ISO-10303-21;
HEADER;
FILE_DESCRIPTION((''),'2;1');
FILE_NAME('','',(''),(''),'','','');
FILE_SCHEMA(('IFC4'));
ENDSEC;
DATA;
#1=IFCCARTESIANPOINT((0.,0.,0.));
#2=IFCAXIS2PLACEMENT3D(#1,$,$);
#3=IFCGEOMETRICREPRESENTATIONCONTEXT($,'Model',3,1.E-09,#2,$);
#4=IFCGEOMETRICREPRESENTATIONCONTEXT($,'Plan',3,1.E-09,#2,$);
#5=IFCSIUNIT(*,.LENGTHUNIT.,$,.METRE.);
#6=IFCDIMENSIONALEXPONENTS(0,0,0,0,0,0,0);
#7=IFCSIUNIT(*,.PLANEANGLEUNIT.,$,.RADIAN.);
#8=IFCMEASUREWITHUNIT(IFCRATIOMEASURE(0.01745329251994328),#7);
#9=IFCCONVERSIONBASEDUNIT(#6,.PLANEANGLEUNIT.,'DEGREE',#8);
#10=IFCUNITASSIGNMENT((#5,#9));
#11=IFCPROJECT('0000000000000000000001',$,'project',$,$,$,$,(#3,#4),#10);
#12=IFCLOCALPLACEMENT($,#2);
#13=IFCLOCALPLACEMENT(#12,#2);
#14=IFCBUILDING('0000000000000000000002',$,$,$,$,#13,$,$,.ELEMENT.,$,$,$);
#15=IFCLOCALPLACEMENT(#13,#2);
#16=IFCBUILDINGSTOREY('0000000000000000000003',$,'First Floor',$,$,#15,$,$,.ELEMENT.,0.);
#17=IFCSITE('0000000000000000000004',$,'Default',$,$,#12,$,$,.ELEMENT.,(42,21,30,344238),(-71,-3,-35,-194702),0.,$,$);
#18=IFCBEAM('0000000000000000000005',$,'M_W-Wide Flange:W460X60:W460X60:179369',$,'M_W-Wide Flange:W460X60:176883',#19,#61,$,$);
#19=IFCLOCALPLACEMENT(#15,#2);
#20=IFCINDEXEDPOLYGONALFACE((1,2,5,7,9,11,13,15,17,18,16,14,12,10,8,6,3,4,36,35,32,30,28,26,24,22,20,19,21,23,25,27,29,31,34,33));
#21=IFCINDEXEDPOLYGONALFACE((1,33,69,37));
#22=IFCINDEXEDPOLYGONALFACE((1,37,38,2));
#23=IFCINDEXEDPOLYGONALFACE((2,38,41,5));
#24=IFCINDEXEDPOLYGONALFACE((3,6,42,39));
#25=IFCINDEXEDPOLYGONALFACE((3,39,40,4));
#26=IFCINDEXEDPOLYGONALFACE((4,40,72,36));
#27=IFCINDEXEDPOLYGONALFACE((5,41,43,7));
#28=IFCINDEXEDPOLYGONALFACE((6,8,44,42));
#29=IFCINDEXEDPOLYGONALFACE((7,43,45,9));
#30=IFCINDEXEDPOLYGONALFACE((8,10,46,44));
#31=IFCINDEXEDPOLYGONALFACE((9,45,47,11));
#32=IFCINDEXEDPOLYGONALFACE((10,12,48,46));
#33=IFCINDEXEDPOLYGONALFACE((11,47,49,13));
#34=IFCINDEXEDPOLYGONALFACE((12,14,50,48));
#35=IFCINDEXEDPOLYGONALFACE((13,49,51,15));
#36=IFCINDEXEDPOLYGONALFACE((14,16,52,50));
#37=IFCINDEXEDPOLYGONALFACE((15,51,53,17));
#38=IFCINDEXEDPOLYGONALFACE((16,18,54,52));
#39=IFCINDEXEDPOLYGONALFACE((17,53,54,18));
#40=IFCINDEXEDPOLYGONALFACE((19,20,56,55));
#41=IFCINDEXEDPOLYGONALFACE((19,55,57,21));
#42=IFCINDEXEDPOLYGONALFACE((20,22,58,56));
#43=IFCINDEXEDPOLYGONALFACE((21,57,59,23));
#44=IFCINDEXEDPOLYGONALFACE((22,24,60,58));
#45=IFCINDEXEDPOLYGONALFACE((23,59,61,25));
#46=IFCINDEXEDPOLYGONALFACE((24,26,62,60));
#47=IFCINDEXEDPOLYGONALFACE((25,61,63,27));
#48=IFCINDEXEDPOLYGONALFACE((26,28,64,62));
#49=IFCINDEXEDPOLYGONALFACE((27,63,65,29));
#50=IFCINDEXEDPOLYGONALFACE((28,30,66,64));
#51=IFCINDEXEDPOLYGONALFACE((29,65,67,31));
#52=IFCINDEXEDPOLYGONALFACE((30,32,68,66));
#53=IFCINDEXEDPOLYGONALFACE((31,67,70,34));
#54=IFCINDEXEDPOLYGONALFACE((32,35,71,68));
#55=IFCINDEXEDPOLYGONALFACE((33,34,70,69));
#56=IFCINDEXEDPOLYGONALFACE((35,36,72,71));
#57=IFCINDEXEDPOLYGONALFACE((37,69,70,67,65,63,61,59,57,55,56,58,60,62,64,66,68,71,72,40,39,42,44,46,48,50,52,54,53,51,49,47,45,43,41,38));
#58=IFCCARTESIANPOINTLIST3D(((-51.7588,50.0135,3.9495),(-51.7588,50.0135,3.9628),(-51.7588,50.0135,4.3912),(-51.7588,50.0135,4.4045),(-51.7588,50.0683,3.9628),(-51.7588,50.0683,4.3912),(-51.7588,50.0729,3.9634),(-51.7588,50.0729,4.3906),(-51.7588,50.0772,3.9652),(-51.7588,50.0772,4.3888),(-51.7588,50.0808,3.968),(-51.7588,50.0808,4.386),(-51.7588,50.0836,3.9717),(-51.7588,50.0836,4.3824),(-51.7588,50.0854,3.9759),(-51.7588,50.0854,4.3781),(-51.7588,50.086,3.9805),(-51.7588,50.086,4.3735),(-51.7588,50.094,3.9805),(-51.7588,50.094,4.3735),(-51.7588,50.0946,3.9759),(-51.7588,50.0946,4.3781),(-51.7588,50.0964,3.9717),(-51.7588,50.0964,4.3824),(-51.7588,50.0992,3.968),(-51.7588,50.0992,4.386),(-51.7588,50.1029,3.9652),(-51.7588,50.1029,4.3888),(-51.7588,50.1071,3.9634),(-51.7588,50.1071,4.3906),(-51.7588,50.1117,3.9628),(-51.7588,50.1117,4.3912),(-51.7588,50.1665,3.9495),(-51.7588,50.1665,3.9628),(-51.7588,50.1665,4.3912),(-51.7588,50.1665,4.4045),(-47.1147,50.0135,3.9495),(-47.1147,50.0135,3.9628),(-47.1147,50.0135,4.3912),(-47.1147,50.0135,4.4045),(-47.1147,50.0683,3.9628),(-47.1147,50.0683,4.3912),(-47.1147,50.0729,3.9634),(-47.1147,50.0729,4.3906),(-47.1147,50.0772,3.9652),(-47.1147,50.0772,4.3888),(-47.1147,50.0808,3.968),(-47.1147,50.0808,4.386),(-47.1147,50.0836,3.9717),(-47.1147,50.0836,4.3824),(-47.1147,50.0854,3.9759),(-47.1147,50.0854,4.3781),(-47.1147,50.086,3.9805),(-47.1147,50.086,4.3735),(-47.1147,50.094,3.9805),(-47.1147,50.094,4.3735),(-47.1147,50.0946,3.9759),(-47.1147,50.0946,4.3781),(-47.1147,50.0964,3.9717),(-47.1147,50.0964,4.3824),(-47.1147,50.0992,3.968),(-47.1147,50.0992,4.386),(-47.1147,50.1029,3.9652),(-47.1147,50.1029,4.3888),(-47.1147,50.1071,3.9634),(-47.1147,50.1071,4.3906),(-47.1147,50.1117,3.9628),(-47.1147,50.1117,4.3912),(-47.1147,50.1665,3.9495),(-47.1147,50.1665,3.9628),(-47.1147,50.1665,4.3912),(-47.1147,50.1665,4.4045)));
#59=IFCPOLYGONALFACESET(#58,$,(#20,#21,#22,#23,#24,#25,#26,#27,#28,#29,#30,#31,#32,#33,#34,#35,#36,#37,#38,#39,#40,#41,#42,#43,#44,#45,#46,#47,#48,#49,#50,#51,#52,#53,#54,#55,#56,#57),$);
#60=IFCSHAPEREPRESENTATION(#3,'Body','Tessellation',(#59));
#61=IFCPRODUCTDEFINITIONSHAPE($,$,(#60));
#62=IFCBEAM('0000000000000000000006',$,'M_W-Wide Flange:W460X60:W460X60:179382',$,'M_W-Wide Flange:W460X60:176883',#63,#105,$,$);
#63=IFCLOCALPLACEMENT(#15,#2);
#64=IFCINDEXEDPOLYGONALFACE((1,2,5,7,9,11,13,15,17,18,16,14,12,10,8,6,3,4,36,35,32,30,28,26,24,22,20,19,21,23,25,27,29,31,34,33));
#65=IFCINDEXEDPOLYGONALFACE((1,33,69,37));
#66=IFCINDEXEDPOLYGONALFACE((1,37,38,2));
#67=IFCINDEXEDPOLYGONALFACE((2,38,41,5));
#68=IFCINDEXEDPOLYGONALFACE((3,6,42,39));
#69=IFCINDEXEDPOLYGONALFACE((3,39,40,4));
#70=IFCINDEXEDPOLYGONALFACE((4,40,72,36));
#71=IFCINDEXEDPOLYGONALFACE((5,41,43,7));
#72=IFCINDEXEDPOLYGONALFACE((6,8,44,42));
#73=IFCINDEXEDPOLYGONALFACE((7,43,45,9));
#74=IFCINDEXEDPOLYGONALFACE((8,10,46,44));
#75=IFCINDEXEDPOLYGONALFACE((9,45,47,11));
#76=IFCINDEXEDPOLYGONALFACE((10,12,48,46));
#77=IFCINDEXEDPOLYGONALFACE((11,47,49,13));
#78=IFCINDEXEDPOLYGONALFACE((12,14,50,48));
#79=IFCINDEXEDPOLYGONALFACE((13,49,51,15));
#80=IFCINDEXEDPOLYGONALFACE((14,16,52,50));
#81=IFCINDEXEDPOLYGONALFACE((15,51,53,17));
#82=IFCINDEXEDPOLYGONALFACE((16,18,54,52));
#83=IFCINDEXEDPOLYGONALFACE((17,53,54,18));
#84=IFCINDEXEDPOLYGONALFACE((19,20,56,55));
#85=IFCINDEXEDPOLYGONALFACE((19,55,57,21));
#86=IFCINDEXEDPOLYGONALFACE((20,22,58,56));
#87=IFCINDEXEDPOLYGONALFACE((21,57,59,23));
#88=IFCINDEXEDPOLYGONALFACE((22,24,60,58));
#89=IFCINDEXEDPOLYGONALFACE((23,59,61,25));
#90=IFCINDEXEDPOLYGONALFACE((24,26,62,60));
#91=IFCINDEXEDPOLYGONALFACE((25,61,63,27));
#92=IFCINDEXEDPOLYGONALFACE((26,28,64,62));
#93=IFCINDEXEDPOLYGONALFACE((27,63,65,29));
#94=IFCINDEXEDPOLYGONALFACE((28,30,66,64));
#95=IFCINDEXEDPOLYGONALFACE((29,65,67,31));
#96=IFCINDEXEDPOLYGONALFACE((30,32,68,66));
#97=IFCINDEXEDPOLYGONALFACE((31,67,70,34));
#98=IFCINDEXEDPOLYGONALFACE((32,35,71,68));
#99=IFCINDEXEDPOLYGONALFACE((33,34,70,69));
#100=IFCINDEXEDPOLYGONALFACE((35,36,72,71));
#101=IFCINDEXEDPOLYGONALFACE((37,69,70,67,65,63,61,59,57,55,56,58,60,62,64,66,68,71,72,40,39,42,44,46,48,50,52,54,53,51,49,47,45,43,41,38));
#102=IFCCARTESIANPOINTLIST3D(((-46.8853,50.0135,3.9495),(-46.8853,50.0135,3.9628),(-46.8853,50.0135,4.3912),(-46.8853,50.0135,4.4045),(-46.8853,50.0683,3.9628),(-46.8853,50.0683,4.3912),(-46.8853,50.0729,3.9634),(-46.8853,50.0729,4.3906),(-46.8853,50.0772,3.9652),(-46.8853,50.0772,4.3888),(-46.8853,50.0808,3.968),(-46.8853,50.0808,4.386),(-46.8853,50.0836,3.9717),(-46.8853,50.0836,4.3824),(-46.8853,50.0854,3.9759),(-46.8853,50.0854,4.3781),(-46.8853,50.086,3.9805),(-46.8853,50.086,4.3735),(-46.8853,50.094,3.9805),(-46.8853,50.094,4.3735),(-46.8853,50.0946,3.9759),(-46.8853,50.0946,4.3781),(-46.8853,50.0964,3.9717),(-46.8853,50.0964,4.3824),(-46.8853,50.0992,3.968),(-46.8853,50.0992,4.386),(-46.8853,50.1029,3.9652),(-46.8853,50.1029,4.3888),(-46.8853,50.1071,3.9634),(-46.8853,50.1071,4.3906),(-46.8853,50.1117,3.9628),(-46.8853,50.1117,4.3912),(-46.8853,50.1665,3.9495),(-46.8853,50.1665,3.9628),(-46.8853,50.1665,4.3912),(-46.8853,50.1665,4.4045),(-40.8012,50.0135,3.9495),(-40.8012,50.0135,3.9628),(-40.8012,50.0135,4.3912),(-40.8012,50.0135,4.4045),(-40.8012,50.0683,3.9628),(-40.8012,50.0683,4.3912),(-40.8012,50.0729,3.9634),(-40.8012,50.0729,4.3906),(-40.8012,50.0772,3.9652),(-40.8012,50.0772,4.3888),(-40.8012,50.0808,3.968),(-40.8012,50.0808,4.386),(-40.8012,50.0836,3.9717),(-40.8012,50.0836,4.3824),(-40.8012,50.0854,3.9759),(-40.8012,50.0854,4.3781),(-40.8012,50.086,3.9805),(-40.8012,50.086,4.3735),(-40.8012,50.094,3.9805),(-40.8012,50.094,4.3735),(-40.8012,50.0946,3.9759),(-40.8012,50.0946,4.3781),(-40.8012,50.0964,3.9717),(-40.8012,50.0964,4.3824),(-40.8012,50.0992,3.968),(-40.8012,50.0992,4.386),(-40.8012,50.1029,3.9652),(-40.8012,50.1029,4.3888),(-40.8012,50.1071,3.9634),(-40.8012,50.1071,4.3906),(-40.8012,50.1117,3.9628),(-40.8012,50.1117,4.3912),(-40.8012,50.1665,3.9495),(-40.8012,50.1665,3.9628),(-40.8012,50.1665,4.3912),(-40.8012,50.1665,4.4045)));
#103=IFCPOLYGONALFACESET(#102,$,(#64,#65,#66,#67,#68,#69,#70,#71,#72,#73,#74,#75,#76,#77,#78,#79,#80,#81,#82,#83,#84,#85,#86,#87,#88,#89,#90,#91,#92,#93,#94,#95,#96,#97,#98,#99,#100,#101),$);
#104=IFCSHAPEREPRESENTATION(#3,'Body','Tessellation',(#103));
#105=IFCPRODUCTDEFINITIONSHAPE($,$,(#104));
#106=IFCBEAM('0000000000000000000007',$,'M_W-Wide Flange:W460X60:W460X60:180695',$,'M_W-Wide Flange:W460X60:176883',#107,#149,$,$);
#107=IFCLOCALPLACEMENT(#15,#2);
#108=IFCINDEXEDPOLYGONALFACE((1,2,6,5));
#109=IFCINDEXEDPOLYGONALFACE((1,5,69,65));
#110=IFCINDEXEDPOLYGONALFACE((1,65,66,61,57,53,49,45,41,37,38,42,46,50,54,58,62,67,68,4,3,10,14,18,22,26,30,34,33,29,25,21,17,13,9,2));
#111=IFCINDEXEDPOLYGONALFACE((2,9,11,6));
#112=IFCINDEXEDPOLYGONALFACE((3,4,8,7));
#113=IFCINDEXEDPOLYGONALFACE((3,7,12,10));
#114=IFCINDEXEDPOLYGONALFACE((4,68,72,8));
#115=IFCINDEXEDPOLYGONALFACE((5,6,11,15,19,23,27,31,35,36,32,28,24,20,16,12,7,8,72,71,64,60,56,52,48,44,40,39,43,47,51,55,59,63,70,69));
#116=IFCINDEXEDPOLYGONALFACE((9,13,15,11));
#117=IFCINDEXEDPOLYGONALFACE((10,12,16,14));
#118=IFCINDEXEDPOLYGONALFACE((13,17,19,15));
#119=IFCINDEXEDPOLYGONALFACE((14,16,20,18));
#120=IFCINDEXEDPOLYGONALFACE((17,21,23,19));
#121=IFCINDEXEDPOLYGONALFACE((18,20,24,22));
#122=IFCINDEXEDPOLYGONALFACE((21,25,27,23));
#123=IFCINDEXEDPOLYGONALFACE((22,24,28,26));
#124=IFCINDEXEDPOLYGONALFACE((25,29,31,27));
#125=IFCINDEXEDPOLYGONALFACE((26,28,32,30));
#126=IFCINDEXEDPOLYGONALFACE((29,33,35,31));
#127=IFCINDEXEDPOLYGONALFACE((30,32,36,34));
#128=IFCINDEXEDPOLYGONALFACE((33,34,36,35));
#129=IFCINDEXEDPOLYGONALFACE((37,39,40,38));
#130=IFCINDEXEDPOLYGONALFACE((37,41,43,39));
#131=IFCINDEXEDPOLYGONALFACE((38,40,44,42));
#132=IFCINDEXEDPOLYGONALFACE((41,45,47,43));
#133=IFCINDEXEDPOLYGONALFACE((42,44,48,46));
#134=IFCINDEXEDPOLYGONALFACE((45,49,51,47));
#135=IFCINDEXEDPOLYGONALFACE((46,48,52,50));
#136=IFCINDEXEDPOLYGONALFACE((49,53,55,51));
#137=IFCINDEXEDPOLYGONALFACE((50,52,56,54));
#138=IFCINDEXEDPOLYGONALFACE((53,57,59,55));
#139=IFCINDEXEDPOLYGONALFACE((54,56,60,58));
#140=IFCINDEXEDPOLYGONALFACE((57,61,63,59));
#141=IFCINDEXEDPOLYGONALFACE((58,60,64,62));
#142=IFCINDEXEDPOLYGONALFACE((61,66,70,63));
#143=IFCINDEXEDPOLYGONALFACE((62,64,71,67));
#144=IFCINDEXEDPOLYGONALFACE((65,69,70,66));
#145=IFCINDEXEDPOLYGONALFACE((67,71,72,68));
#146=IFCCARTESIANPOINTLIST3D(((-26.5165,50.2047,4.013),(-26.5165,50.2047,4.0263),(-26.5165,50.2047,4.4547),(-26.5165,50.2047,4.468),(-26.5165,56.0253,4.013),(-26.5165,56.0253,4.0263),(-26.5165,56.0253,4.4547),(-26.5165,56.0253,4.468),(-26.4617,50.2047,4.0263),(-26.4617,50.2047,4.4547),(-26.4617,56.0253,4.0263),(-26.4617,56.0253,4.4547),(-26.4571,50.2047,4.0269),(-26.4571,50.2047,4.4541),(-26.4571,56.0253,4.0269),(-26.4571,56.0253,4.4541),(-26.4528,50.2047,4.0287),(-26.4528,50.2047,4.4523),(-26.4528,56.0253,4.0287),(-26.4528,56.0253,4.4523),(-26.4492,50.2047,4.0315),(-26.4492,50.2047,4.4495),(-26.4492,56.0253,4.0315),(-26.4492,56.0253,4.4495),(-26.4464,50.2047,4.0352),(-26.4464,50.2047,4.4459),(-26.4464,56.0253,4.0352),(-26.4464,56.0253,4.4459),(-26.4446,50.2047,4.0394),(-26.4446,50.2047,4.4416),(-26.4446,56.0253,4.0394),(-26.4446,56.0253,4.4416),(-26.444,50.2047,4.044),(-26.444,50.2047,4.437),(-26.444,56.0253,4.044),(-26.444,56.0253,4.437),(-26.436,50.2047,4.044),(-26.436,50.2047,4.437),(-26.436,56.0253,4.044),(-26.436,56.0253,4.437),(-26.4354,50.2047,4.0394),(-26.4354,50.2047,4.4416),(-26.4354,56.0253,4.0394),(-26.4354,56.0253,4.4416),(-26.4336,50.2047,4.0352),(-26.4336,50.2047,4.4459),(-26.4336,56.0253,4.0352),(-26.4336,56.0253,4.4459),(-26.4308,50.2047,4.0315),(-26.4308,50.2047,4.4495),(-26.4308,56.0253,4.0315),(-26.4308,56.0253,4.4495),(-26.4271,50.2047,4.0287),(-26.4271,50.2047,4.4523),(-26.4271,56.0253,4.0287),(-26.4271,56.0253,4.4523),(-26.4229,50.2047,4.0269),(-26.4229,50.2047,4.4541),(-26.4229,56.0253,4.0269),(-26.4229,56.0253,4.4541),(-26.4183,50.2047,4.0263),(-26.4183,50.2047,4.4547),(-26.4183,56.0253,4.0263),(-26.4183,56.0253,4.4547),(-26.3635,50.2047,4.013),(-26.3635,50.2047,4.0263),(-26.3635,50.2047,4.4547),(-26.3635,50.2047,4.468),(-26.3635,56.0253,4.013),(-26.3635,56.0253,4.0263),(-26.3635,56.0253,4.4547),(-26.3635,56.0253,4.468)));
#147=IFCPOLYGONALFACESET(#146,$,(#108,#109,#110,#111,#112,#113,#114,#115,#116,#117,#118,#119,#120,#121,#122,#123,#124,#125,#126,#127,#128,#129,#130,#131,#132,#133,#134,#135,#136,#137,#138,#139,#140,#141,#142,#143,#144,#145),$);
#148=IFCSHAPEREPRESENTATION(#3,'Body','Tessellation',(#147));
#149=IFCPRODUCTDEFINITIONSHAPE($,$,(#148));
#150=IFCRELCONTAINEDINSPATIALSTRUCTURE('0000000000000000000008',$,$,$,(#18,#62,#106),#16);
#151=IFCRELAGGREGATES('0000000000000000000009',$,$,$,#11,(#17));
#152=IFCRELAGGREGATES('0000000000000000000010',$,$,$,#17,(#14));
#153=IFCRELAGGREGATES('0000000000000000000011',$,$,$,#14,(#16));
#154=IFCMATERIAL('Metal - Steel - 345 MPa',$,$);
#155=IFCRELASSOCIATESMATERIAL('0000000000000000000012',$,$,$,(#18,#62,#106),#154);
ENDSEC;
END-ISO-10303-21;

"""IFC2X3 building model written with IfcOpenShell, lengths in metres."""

from ifc_helpers import new_model, entity, si_unit, converted_unit, frame, frame_2d, origin, place, context, project, spatial, polyline, circle_curve, parameter, trimmed, segment, composite_curve, outline, extrude, material, element, save


model = new_model("IFC2X3")

# Units and contexts
model_context = context("Model", 3, precision=1e-09, world=origin())
plan_context = context("Plan", 3, precision=1e-09, world=origin())
ifc_project = project(units=[si_unit("LENGTHUNIT", "METRE"), converted_unit("PLANEANGLEUNIT", "DEGREE", entity("IfcRatioMeasure", 0.01745329251994328), si_unit("PLANEANGLEUNIT", "RADIAN"), dimensions=[0, 0, 0, 0, 0, 0, 0])], contexts=[model_context, plan_context])

# Site, building, storey
site_placement = place(None, origin())
site = spatial("IfcSite", under=ifc_project, at=site_placement, Name="Default", CompositionType="ELEMENT", RefLatitude=(42, 21, 30, 344238), RefLongitude=(-71, -3, -35, -194702), RefElevation=0.0)
building_placement = place(site_placement, origin())
building = spatial("IfcBuilding", under=site, at=building_placement, CompositionType="ELEMENT")
storey_placement = place(building_placement, origin())
storey = spatial("IfcBuildingStorey", under=building, at=storey_placement, Name="First Floor", CompositionType="ELEMENT", Elevation=0.0)

# Beams
ifc_material = material(Name="Metal - Steel - 345 MPa")
beam_1_placement = place(storey_placement, frame((-51.9028, 50.09, 4.4045), z_axis=(0.0, 0.0, 1.0), x_axis=(0.0, -1.0, 0.0)))
element("IfcBeam", 1, at=beam_1_placement, inside=storey, material=ifc_material, Name="M_W-Wide Flange:W460X60:W460X60:179369", ObjectType="M_W-Wide Flange:W460X60:176883", context=model_context, shape_type="SweptSolid", body=[
    extrude(outline(composite_curve([segment(polyline([(-0.0765, -0.2142), (-0.0765, -0.2275)]), True, "CONTINUOUS"), segment(polyline([(-0.0765, -0.2275), (0.0765, -0.2275)]), True, "CONTINUOUS"), segment(polyline([(0.0765, -0.2275), (0.0765, -0.2142)]), True, "CONTINUOUS"), segment(polyline([(0.0765, -0.2142), (0.0217, -0.2142)]), True, "CONTINUOUS"), segment(trimmed(circle_curve(frame_2d((0.0217, -0.1965), x_axis=(1.0, 0.0)), 0.0177), [parameter(180.0)], [parameter(270.0)], True, "PARAMETER"), False, "CONTINUOUS"), segment(polyline([(0.004, -0.1965), (0.004, 0.1965)]), True, "CONTINUOUS"), segment(trimmed(circle_curve(frame_2d((0.0217, 0.1965), x_axis=(1.0, 0.0)), 0.0177), [parameter(90.0)], [parameter(180.0)], True, "PARAMETER"), False, "CONTINUOUS"), segment(polyline([(0.0217, 0.2142), (0.0765, 0.2142)]), True, "CONTINUOUS"), segment(polyline([(0.0765, 0.2142), (0.0765, 0.2275)]), True, "CONTINUOUS"), segment(polyline([(0.0765, 0.2275), (-0.0765, 0.2275)]), True, "CONTINUOUS"), segment(polyline([(-0.0765, 0.2275), (-0.0765, 0.2142)]), True, "CONTINUOUS"), segment(polyline([(-0.0765, 0.2142), (-0.0217, 0.2142)]), True, "CONTINUOUS"), segment(trimmed(circle_curve(frame_2d((-0.0217, 0.1965), x_axis=(1.0, 0.0)), 0.0177), [parameter(360.0)], [parameter(90.0)], True, "PARAMETER"), False, "CONTINUOUS"), segment(polyline([(-0.004, 0.1965), (-0.004, -0.1965)]), True, "CONTINUOUS"), segment(trimmed(circle_curve(frame_2d((-0.0217, -0.1965), x_axis=(1.0, 0.0)), 0.0177), [parameter(270.0)], [parameter(0.0)], True, "PARAMETER"), False, "CONTINUOUS"), segment(polyline([(-0.0217, -0.2142), (-0.0765, -0.2142)]), True, "CONTINUOUS")], self_intersect=False)), frame((0.0, 0.144, -0.2275), z_axis=(0.0, -1.0, 0.0), x_axis=(1.0, 0.0, 0.0)), (0.0, 0.0, -1.0), 4.6441),
])
beam_2_placement = place(storey_placement, frame((-47.0022, 50.09, 4.4045), z_axis=(0.0, 0.0, 1.0), x_axis=(0.0, -1.0, 0.0)))
element("IfcBeam", 2, at=beam_2_placement, inside=storey, material=ifc_material, Name="M_W-Wide Flange:W460X60:W460X60:179382", ObjectType="M_W-Wide Flange:W460X60:176883", context=model_context, shape_type="SweptSolid", body=[
    extrude(outline(composite_curve([segment(polyline([(-0.0765, -0.2142), (-0.0765, -0.2275)]), True, "CONTINUOUS"), segment(polyline([(-0.0765, -0.2275), (0.0765, -0.2275)]), True, "CONTINUOUS"), segment(polyline([(0.0765, -0.2275), (0.0765, -0.2142)]), True, "CONTINUOUS"), segment(polyline([(0.0765, -0.2142), (0.0217, -0.2142)]), True, "CONTINUOUS"), segment(trimmed(circle_curve(frame_2d((0.0217, -0.1965), x_axis=(0.0, -1.0)), 0.0177), [parameter(270.0)], [parameter(360.0)], True, "PARAMETER"), False, "CONTINUOUS"), segment(polyline([(0.004, -0.1965), (0.004, 0.1965)]), True, "CONTINUOUS"), segment(trimmed(circle_curve(frame_2d((0.0217, 0.1965), x_axis=(-1.0, 0.0)), 0.0177), [parameter(270.0)], [parameter(360.0)], True, "PARAMETER"), False, "CONTINUOUS"), segment(polyline([(0.0217, 0.2142), (0.0765, 0.2142)]), True, "CONTINUOUS"), segment(polyline([(0.0765, 0.2142), (0.0765, 0.2275)]), True, "CONTINUOUS"), segment(polyline([(0.0765, 0.2275), (-0.0765, 0.2275)]), True, "CONTINUOUS"), segment(polyline([(-0.0765, 0.2275), (-0.0765, 0.2142)]), True, "CONTINUOUS"), segment(polyline([(-0.0765, 0.2142), (-0.0217, 0.2142)]), True, "CONTINUOUS"), segment(trimmed(circle_curve(frame_2d((-0.0217, 0.1965), x_axis=(0.0, 1.0)), 0.0177), [parameter(270.0)], [parameter(360.0)], True, "PARAMETER"), False, "CONTINUOUS"), segment(polyline([(-0.004, 0.1965), (-0.004, -0.1965)]), True, "CONTINUOUS"), segment(trimmed(circle_curve(frame_2d((-0.0217, -0.1965), x_axis=(1.0, 0.0)), 0.0177), [parameter(270.0)], [parameter(0.0)], True, "PARAMETER"), False, "CONTINUOUS"), segment(polyline([(-0.0217, -0.2142), (-0.0765, -0.2142)]), True, "CONTINUOUS")], self_intersect=False)), frame((0.0, 0.1169, -0.2275), z_axis=(0.0, -1.0, 0.0), x_axis=(1.0, 0.0, 0.0)), (0.0, 0.0, -1.0), 6.0841),
])
beam_3_placement = place(storey_placement, frame((-26.44, 56.1423, 4.468), z_axis=(0.0, 0.0, 1.0), x_axis=(-1.0, 0.0, 0.0)))
element("IfcBeam", 3, at=beam_3_placement, inside=storey, material=ifc_material, Name="M_W-Wide Flange:W460X60:W460X60:180695", ObjectType="M_W-Wide Flange:W460X60:176883", context=model_context, shape_type="SweptSolid", body=[
    extrude(outline(composite_curve([segment(polyline([(0.2142, -0.0765), (0.2275, -0.0765)]), True, "CONTINUOUS"), segment(polyline([(0.2275, -0.0765), (0.2275, 0.0765)]), True, "CONTINUOUS"), segment(polyline([(0.2275, 0.0765), (0.2142, 0.0765)]), True, "CONTINUOUS"), segment(polyline([(0.2142, 0.0765), (0.2142, 0.0217)]), True, "CONTINUOUS"), segment(trimmed(circle_curve(frame_2d((0.1965, 0.0217), x_axis=(0.0, 1.0)), 0.0177), [parameter(180.0)], [parameter(270.0)], True, "PARAMETER"), False, "CONTINUOUS"), segment(polyline([(0.1965, 0.004), (-0.1965, 0.004)]), True, "CONTINUOUS"), segment(trimmed(circle_curve(frame_2d((-0.1965, 0.0217), x_axis=(0.0, 1.0)), 0.0177), [parameter(90.0)], [parameter(180.0)], True, "PARAMETER"), False, "CONTINUOUS"), segment(polyline([(-0.2142, 0.0217), (-0.2142, 0.0765)]), True, "CONTINUOUS"), segment(polyline([(-0.2142, 0.0765), (-0.2275, 0.0765)]), True, "CONTINUOUS"), segment(polyline([(-0.2275, 0.0765), (-0.2275, -0.0765)]), True, "CONTINUOUS"), segment(polyline([(-0.2275, -0.0765), (-0.2142, -0.0765)]), True, "CONTINUOUS"), segment(polyline([(-0.2142, -0.0765), (-0.2142, -0.0217)]), True, "CONTINUOUS"), segment(trimmed(circle_curve(frame_2d((-0.1965, -0.0217), x_axis=(0.0, 1.0)), 0.0177), [parameter(360.0)], [parameter(90.0)], True, "PARAMETER"), False, "CONTINUOUS"), segment(polyline([(-0.1965, -0.004), (0.1965, -0.004)]), True, "CONTINUOUS"), segment(trimmed(circle_curve(frame_2d((0.1965, -0.0217), x_axis=(0.0, 1.0)), 0.0177), [parameter(270.0)], [parameter(0.0)], True, "PARAMETER"), False, "CONTINUOUS"), segment(polyline([(0.2142, -0.0217), (0.2142, -0.0765)]), True, "CONTINUOUS")], self_intersect=False)), frame((0.0, 5.9376, -0.2275), z_axis=(0.0, -1.0, 0.0), x_axis=(0.0, 0.0, -1.0)), (0.0, 0.0, 1.0), 5.8206),
])

save(model, "model.ifc")
